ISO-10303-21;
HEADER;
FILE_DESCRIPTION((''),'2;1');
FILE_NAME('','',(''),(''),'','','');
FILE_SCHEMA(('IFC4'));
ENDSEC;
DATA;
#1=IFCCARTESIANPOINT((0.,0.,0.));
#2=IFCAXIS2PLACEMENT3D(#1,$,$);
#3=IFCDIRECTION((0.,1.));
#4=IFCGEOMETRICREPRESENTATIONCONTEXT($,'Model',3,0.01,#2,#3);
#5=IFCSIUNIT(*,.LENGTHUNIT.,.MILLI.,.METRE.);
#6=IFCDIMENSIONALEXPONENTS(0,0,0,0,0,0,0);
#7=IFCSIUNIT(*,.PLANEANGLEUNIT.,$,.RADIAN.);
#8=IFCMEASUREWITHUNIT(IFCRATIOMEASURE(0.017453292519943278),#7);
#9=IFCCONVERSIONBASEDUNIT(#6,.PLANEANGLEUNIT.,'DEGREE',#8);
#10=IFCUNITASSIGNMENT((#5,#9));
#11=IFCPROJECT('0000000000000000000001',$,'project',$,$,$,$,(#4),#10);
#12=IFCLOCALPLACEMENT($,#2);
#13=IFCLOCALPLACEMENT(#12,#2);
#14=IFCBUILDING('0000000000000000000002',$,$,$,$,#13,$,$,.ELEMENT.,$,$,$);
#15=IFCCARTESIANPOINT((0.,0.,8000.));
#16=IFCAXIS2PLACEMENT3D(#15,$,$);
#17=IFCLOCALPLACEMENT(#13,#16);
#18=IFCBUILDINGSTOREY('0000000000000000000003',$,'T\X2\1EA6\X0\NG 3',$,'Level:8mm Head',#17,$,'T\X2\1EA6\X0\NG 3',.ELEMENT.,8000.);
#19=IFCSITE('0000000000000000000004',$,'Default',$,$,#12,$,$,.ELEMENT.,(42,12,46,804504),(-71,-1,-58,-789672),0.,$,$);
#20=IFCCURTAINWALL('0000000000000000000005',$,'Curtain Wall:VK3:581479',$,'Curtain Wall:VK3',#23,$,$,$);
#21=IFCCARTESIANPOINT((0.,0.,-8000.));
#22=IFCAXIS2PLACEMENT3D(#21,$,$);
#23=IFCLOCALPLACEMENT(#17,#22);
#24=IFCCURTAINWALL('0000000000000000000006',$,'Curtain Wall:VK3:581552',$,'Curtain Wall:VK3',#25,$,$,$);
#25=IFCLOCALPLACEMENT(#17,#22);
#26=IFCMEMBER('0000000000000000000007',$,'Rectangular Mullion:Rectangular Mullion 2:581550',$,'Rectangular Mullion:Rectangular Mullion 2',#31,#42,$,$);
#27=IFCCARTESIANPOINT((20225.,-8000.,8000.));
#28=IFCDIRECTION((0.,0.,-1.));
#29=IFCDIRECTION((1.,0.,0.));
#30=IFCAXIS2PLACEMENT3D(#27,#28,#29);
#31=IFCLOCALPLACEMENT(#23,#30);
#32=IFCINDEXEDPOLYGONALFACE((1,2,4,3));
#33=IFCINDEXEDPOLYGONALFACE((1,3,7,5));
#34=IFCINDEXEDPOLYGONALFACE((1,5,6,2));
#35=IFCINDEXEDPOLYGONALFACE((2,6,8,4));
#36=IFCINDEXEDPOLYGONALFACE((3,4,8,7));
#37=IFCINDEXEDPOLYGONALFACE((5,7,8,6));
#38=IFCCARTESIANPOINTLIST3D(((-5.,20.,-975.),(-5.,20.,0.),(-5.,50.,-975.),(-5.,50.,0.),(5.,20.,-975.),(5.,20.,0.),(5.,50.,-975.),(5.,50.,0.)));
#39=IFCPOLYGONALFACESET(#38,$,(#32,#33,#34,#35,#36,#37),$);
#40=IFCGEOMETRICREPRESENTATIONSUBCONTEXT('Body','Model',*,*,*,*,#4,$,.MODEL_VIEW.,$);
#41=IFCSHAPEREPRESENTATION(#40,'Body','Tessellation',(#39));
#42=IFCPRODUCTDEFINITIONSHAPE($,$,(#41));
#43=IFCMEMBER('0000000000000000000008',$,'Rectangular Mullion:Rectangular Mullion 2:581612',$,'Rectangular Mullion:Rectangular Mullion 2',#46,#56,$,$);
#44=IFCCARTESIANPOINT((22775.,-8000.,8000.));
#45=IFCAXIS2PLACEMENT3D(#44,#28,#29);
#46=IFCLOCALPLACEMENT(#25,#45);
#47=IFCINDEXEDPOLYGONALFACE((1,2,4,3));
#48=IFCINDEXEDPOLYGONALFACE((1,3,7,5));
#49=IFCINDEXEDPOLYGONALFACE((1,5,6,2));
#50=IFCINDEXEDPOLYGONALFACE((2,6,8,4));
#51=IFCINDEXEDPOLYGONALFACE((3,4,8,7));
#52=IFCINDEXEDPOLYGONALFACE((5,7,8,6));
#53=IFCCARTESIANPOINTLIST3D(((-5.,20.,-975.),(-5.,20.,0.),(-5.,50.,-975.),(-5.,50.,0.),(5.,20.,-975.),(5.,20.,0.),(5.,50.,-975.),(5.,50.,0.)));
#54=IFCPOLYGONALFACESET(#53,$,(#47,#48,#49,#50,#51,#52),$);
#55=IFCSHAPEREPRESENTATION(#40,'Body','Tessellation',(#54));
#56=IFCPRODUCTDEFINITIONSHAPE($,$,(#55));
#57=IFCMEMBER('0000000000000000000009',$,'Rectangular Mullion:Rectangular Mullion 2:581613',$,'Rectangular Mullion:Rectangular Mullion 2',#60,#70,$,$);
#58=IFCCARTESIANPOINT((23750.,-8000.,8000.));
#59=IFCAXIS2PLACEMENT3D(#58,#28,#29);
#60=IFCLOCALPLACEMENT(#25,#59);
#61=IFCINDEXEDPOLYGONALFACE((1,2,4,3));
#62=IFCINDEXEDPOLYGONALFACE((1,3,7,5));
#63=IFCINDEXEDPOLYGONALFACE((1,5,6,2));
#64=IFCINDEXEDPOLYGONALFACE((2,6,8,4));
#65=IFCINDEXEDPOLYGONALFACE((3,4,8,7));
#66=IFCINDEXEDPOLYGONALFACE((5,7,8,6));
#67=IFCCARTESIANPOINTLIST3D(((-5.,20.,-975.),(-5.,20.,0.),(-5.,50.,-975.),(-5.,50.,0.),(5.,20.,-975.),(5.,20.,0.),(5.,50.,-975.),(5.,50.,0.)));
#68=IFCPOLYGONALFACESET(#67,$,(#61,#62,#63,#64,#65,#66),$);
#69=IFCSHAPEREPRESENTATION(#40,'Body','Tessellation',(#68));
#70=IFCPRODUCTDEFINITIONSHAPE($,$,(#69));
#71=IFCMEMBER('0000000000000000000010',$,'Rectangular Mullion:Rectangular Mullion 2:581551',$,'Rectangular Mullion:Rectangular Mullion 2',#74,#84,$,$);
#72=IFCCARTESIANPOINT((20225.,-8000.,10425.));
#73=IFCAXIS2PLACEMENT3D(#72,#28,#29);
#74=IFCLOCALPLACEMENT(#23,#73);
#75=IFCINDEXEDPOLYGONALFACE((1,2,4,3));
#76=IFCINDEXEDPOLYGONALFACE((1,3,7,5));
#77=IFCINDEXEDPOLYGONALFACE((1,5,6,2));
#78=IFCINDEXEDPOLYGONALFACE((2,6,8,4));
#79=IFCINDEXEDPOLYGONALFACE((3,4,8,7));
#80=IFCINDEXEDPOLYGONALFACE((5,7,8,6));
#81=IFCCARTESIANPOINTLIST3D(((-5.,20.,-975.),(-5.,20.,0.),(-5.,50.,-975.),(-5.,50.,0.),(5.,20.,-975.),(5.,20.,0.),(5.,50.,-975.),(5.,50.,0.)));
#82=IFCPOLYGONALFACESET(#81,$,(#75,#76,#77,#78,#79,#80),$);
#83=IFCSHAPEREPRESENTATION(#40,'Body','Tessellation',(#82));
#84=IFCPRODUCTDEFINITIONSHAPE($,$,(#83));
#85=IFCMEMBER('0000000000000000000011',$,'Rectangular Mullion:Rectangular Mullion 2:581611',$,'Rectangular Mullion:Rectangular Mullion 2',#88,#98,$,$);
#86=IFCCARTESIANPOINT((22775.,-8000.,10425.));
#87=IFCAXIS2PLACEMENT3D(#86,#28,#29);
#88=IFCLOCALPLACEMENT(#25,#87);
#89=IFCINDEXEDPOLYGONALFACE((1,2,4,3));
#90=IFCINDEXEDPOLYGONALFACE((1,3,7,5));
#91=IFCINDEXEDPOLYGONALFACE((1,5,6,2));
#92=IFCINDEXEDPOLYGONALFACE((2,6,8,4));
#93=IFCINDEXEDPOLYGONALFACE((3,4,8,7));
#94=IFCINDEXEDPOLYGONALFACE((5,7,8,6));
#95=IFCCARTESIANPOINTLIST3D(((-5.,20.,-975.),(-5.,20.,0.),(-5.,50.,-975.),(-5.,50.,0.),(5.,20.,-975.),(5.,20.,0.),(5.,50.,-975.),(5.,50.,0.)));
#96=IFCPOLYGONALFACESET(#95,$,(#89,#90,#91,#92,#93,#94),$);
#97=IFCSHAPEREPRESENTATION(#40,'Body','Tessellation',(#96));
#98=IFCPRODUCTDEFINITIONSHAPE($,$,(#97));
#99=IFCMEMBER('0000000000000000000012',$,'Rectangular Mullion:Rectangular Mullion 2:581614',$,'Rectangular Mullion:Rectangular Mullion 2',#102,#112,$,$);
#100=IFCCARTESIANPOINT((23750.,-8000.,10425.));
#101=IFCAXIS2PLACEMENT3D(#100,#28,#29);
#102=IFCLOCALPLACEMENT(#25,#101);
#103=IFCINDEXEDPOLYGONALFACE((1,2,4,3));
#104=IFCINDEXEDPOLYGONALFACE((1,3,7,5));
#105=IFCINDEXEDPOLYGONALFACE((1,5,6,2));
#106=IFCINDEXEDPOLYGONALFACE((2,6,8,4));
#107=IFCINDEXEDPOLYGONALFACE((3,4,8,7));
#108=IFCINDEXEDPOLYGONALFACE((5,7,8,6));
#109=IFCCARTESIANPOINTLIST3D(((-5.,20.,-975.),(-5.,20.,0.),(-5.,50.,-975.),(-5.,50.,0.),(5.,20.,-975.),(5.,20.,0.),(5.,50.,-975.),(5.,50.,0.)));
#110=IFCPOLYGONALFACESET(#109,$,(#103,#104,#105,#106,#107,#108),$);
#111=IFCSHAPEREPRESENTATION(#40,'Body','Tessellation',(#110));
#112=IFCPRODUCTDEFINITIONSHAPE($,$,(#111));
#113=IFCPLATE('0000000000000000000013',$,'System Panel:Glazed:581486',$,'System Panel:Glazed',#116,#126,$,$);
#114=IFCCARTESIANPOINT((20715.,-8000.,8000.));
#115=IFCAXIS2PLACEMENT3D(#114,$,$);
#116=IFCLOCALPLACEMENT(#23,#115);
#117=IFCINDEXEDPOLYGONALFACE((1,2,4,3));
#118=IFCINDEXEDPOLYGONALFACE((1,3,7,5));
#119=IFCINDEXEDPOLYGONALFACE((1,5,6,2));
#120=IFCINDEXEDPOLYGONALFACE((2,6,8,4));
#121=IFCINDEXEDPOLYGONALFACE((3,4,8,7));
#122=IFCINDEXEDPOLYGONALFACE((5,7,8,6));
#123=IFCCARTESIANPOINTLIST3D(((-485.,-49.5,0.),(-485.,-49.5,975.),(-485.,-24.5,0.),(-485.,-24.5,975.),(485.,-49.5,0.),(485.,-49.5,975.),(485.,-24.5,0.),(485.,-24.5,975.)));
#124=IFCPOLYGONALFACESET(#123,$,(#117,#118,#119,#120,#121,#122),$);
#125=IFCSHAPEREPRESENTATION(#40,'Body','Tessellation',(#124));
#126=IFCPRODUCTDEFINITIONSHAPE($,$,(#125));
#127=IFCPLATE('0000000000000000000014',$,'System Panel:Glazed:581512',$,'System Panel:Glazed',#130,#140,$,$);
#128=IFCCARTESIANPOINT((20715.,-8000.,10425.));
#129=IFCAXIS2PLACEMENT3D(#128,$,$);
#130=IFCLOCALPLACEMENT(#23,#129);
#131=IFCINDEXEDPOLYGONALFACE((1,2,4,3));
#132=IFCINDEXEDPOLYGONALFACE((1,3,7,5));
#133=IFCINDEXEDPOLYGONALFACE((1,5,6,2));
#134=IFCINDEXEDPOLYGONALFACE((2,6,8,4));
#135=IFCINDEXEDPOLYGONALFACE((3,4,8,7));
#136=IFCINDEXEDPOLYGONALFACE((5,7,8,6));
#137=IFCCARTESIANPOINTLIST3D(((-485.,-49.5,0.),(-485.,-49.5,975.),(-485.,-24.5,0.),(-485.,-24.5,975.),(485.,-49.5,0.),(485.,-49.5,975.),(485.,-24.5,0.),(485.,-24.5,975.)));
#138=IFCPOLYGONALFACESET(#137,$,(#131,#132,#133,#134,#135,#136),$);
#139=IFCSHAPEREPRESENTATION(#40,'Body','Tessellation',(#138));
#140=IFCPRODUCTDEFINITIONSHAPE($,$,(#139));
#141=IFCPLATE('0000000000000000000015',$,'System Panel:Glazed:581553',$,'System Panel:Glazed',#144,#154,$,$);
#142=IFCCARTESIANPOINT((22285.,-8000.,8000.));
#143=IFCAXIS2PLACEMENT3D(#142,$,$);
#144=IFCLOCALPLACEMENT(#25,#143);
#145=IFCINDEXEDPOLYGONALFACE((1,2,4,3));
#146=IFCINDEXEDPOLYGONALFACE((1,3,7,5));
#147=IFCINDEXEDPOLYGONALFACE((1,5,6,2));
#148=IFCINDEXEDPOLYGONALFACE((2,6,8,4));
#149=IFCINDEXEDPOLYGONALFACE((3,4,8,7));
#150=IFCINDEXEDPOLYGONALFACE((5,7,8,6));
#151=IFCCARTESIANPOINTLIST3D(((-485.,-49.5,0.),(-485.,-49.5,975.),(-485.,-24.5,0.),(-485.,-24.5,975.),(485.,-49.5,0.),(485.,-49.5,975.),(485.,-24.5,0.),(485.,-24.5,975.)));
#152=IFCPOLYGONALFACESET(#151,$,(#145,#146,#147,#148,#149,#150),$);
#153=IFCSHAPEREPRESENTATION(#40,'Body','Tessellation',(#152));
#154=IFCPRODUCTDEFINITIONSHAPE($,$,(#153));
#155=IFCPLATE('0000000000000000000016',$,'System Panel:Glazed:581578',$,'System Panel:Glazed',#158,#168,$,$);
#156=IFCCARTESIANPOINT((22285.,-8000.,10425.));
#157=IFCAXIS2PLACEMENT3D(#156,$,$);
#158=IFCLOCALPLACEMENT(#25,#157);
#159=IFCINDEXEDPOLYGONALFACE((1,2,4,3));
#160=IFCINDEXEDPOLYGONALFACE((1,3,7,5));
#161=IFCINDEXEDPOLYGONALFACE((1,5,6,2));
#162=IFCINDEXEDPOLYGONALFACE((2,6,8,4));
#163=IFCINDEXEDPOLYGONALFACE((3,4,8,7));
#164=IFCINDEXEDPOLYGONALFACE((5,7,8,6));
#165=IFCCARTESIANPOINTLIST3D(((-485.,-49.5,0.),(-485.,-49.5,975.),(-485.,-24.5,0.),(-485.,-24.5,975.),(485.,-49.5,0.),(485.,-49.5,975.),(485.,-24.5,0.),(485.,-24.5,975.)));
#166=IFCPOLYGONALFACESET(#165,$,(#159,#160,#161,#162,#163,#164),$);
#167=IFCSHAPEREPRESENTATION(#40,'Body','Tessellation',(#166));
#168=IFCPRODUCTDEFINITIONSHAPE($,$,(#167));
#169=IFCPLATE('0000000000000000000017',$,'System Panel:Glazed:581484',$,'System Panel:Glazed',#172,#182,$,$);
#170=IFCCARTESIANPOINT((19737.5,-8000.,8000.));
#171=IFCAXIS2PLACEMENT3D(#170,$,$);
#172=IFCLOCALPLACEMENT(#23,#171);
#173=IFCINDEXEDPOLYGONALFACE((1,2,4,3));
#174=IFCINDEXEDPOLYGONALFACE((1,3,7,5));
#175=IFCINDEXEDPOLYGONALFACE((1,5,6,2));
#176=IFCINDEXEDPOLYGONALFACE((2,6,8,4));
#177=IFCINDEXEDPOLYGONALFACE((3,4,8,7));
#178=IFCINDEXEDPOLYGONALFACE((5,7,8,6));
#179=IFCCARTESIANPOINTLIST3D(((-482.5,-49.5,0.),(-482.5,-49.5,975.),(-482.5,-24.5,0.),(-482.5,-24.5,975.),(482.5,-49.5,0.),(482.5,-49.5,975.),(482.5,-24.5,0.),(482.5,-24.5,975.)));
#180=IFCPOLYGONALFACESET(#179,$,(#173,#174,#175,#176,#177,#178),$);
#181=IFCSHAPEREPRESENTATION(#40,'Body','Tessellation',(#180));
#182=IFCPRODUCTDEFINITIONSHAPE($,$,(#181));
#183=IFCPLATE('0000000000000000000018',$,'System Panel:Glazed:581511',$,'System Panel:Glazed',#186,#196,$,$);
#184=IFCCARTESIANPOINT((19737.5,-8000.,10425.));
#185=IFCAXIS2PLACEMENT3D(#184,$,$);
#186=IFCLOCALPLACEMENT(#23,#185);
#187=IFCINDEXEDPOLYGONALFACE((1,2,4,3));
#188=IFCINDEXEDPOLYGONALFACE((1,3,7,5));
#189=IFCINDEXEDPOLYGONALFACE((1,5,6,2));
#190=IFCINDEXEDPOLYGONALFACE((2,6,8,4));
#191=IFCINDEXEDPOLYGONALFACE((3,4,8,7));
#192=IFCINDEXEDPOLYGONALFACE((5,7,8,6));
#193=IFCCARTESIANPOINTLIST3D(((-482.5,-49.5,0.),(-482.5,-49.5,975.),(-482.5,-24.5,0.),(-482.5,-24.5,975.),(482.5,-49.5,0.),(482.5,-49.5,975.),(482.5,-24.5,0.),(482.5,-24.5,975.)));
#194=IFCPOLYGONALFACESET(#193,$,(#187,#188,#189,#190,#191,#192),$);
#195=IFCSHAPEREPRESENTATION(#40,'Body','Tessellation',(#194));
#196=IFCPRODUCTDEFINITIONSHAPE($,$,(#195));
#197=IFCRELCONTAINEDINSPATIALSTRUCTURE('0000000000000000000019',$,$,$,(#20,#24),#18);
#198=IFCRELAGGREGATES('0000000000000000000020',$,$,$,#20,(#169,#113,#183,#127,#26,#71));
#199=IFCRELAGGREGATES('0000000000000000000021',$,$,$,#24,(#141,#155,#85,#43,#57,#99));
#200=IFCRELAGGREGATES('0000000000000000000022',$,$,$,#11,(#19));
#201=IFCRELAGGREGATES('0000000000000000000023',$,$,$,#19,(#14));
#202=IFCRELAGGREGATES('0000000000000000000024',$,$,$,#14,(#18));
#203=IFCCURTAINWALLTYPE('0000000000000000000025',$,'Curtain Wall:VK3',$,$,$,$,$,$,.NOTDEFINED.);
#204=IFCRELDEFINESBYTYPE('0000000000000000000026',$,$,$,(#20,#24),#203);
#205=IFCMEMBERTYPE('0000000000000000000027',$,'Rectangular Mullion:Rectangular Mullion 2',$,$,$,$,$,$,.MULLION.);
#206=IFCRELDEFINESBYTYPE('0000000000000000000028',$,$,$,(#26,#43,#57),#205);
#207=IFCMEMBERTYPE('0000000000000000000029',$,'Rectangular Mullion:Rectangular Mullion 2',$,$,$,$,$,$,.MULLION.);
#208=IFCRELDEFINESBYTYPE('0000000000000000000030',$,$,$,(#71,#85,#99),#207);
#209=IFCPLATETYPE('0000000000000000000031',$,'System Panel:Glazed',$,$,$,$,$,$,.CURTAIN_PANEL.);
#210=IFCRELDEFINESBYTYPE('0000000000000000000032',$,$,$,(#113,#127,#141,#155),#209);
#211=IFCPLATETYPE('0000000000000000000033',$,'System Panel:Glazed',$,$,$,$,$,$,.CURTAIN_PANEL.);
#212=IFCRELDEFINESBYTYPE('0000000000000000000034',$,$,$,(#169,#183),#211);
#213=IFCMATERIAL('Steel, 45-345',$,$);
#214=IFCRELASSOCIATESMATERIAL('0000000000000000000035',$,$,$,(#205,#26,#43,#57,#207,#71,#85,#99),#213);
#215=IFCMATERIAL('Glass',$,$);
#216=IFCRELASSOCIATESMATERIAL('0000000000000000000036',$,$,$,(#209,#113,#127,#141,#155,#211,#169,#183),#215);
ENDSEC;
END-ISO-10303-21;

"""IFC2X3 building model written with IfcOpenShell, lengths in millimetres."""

from ifc_helpers import new_model, entity, si_unit, converted_unit, direction, frame, frame_2d, origin, origin_2d_with_axis, place, context, subcontext, project, spatial, rectangle, extrude, source, transform, mapped, material, type_object, type_shapes, element, aggregate, save


model = new_model("IFC2X3")

# Units and contexts
model_context = context("Model", 3, precision=0.01, world=origin(), true_north=direction((0.0, 1.0)))
body_context = subcontext(model_context, "Body", "Model", "MODEL_VIEW")
ifc_project = project(units=[si_unit("LENGTHUNIT", "METRE", prefix="MILLI"), converted_unit("PLANEANGLEUNIT", "DEGREE", entity("IfcRatioMeasure", 0.017453292519943278), si_unit("PLANEANGLEUNIT", "RADIAN"), dimensions=[0, 0, 0, 0, 0, 0, 0])], contexts=[model_context])

# Site, building, storey
site_placement = place(None, origin())
site = spatial("IfcSite", under=ifc_project, at=site_placement, Name="Default", CompositionType="ELEMENT", RefLatitude=(42, 12, 46, 804504), RefLongitude=(-71, -1, -58, -789672), RefElevation=0.0)
building_placement = place(site_placement, origin())
building = spatial("IfcBuilding", under=site, at=building_placement, CompositionType="ELEMENT")
storey_placement = place(building_placement, frame((0.0, 0.0, 8000.0)))
storey = spatial("IfcBuildingStorey", under=building, at=storey_placement, Name="TẦNG 3", ObjectType="Level:8mm Head", LongName="TẦNG 3", CompositionType="ELEMENT", Elevation=8000.0)

# Curtain wall
curtain_wall_type = type_object("IfcCurtainWallType", Name="Curtain Wall:VK3", PredefinedType="NOTDEFINED")
curtain_wall_1_placement = place(storey_placement, frame((0.0, 0.0, -8000.0)))
curtain_wall_1 = element("IfcCurtainWall", 1, at=curtain_wall_1_placement, inside=storey, type_object=curtain_wall_type, Name="Curtain Wall:VK3:581479", ObjectType="Curtain Wall:VK3")
ifc_material_1 = material(Name="Steel, 45-345")

# Curtain wall
curtain_wall_2_placement = place(storey_placement, frame((0.0, 0.0, -8000.0)))
curtain_wall_2 = element("IfcCurtainWall", 2, at=curtain_wall_2_placement, inside=storey, type_object=curtain_wall_type, Name="Curtain Wall:VK3:581552", ObjectType="Curtain Wall:VK3")

# Members
member_type_1 = type_object("IfcMemberType", Name="Rectangular Mullion:Rectangular Mullion 2", PredefinedType="MULLION", material=ifc_material_1)
shared_shape_1 = source(origin(), body_context, "Body", "SweptSolid", [
    extrude(rectangle(XDim=30.0, YDim=10.0, at=origin_2d_with_axis()), frame((0.0, 35.0, -975.0), z_axis=(0.0, 0.0, 1.0), x_axis=(0.0, -1.0, 0.0)), (0.0, 0.0, 1.0), 975.0),
])
type_shapes(member_type_1, [shared_shape_1])
member_1_placement = place(curtain_wall_1_placement, frame((20225.0, -8000.0, 8000.0), z_axis=(0.0, 0.0, -1.0), x_axis=(1.0, 0.0, 0.0)))
member_1 = element("IfcMember", 3, at=member_1_placement, type_object=member_type_1, material=ifc_material_1, Name="Rectangular Mullion:Rectangular Mullion 2:581550", ObjectType="Rectangular Mullion:Rectangular Mullion 2", context=body_context, shape_type="MappedRepresentation", body=[
    mapped(shared_shape_1, transform((0.0, 0.0, 0.0), scale=1.0)),
])
member_2_placement = place(curtain_wall_2_placement, frame((22775.0, -8000.0, 8000.0), z_axis=(0.0, 0.0, -1.0), x_axis=(1.0, 0.0, 0.0)))
member_2 = element("IfcMember", 4, at=member_2_placement, type_object=member_type_1, material=ifc_material_1, Name="Rectangular Mullion:Rectangular Mullion 2:581612", ObjectType="Rectangular Mullion:Rectangular Mullion 2", context=body_context, shape_type="MappedRepresentation", body=[
    mapped(shared_shape_1, transform((0.0, 0.0, 0.0), scale=1.0)),
])
member_3_placement = place(curtain_wall_2_placement, frame((23750.0, -8000.0, 8000.0), z_axis=(0.0, 0.0, -1.0), x_axis=(1.0, 0.0, 0.0)))
member_3 = element("IfcMember", 5, at=member_3_placement, type_object=member_type_1, material=ifc_material_1, Name="Rectangular Mullion:Rectangular Mullion 2:581613", ObjectType="Rectangular Mullion:Rectangular Mullion 2", context=body_context, shape_type="MappedRepresentation", body=[
    mapped(shared_shape_1, transform((0.0, 0.0, 0.0), scale=1.0)),
])
member_type_2 = type_object("IfcMemberType", Name="Rectangular Mullion:Rectangular Mullion 2", PredefinedType="MULLION", material=ifc_material_1)
shared_shape_2 = source(origin(), body_context, "Body", "SweptSolid", [
    extrude(rectangle(XDim=30.0, YDim=10.0, at=origin_2d_with_axis()), frame((0.0, 35.0, -975.0), z_axis=(0.0, 0.0, 1.0), x_axis=(0.0, -1.0, 0.0)), (0.0, 0.0, 1.0), 975.0),
])
type_shapes(member_type_2, [shared_shape_2])
member_4_placement = place(curtain_wall_1_placement, frame((20225.0, -8000.0, 10425.0), z_axis=(0.0, 0.0, -1.0), x_axis=(1.0, 0.0, 0.0)))
member_4 = element("IfcMember", 6, at=member_4_placement, type_object=member_type_2, material=ifc_material_1, Name="Rectangular Mullion:Rectangular Mullion 2:581551", ObjectType="Rectangular Mullion:Rectangular Mullion 2", context=body_context, shape_type="MappedRepresentation", body=[
    mapped(shared_shape_2, transform((0.0, 0.0, 0.0), scale=1.0)),
])
member_5_placement = place(curtain_wall_2_placement, frame((22775.0, -8000.0, 10425.0), z_axis=(0.0, 0.0, -1.0), x_axis=(1.0, 0.0, 0.0)))
member_5 = element("IfcMember", 7, at=member_5_placement, type_object=member_type_2, material=ifc_material_1, Name="Rectangular Mullion:Rectangular Mullion 2:581611", ObjectType="Rectangular Mullion:Rectangular Mullion 2", context=body_context, shape_type="MappedRepresentation", body=[
    mapped(shared_shape_2, transform((0.0, 0.0, 0.0), scale=1.0)),
])
member_6_placement = place(curtain_wall_2_placement, frame((23750.0, -8000.0, 10425.0), z_axis=(0.0, 0.0, -1.0), x_axis=(1.0, 0.0, 0.0)))
member_6 = element("IfcMember", 8, at=member_6_placement, type_object=member_type_2, material=ifc_material_1, Name="Rectangular Mullion:Rectangular Mullion 2:581614", ObjectType="Rectangular Mullion:Rectangular Mullion 2", context=body_context, shape_type="MappedRepresentation", body=[
    mapped(shared_shape_2, transform((0.0, 0.0, 0.0), scale=1.0)),
])

# Plates
ifc_material_2 = material(Name="Glass")
plate_type_1 = type_object("IfcPlateType", Name="System Panel:Glazed", PredefinedType="CURTAIN_PANEL", material=ifc_material_2)
shared_shape_3 = source(origin(), body_context, "Body", "SweptSolid", [
    extrude(rectangle(XDim=25.0, YDim=970.0, at=frame_2d((0.0, 0.0), x_axis=(1.0, 0.0))), frame((0.0, -37.0, 0.0), z_axis=(0.0, 0.0, 1.0), x_axis=(0.0, 1.0, 0.0)), (0.0, 0.0, 1.0), 975.0),
])
type_shapes(plate_type_1, [shared_shape_3])
plate_1_placement = place(curtain_wall_1_placement, frame((20715.0, -8000.0, 8000.0)))
plate_1 = element("IfcPlate", 9, at=plate_1_placement, type_object=plate_type_1, material=ifc_material_2, Name="System Panel:Glazed:581486", ObjectType="System Panel:Glazed", context=body_context, shape_type="MappedRepresentation", body=[
    mapped(shared_shape_3, transform((0.0, 0.0, 0.0), scale=1.0)),
])
plate_2_placement = place(curtain_wall_1_placement, frame((20715.0, -8000.0, 10425.0)))
plate_2 = element("IfcPlate", 10, at=plate_2_placement, type_object=plate_type_1, material=ifc_material_2, Name="System Panel:Glazed:581512", ObjectType="System Panel:Glazed", context=body_context, shape_type="MappedRepresentation", body=[
    mapped(shared_shape_3, transform((0.0, 0.0, 0.0), scale=1.0)),
])
plate_3_placement = place(curtain_wall_2_placement, frame((22285.0, -8000.0, 8000.0)))
plate_3 = element("IfcPlate", 11, at=plate_3_placement, type_object=plate_type_1, material=ifc_material_2, Name="System Panel:Glazed:581553", ObjectType="System Panel:Glazed", context=body_context, shape_type="MappedRepresentation", body=[
    mapped(shared_shape_3, transform((0.0, 0.0, 0.0), scale=1.0)),
])
plate_4_placement = place(curtain_wall_2_placement, frame((22285.0, -8000.0, 10425.0)))
plate_4 = element("IfcPlate", 12, at=plate_4_placement, type_object=plate_type_1, material=ifc_material_2, Name="System Panel:Glazed:581578", ObjectType="System Panel:Glazed", context=body_context, shape_type="MappedRepresentation", body=[
    mapped(shared_shape_3, transform((0.0, 0.0, 0.0), scale=1.0)),
])
plate_type_2 = type_object("IfcPlateType", Name="System Panel:Glazed", PredefinedType="CURTAIN_PANEL", material=ifc_material_2)
shared_shape_4 = source(origin(), body_context, "Body", "SweptSolid", [
    extrude(rectangle(XDim=25.0, YDim=965.0, at=frame_2d((0.0, 0.0), x_axis=(1.0, 0.0))), frame((0.0, -37.0, 0.0), z_axis=(0.0, 0.0, 1.0), x_axis=(0.0, 1.0, 0.0)), (0.0, 0.0, 1.0), 975.0),
])
type_shapes(plate_type_2, [shared_shape_4])
plate_5_placement = place(curtain_wall_1_placement, frame((19737.5, -8000.0, 8000.0)))
plate_5 = element("IfcPlate", 13, at=plate_5_placement, type_object=plate_type_2, material=ifc_material_2, Name="System Panel:Glazed:581484", ObjectType="System Panel:Glazed", context=body_context, shape_type="MappedRepresentation", body=[
    mapped(shared_shape_4, transform((0.0, 0.0, 0.0), scale=1.0)),
])
plate_6_placement = place(curtain_wall_1_placement, frame((19737.5, -8000.0, 10425.0)))
plate_6 = element("IfcPlate", 14, at=plate_6_placement, type_object=plate_type_2, material=ifc_material_2, Name="System Panel:Glazed:581511", ObjectType="System Panel:Glazed", context=body_context, shape_type="MappedRepresentation", body=[
    mapped(shared_shape_4, transform((0.0, 0.0, 0.0), scale=1.0)),
])
aggregate(curtain_wall_1, [plate_5, plate_1, plate_6, plate_2, member_1, member_4])
aggregate(curtain_wall_2, [plate_3, plate_4, member_5, member_2, member_3, member_6])

save(model, "model.ifc")
